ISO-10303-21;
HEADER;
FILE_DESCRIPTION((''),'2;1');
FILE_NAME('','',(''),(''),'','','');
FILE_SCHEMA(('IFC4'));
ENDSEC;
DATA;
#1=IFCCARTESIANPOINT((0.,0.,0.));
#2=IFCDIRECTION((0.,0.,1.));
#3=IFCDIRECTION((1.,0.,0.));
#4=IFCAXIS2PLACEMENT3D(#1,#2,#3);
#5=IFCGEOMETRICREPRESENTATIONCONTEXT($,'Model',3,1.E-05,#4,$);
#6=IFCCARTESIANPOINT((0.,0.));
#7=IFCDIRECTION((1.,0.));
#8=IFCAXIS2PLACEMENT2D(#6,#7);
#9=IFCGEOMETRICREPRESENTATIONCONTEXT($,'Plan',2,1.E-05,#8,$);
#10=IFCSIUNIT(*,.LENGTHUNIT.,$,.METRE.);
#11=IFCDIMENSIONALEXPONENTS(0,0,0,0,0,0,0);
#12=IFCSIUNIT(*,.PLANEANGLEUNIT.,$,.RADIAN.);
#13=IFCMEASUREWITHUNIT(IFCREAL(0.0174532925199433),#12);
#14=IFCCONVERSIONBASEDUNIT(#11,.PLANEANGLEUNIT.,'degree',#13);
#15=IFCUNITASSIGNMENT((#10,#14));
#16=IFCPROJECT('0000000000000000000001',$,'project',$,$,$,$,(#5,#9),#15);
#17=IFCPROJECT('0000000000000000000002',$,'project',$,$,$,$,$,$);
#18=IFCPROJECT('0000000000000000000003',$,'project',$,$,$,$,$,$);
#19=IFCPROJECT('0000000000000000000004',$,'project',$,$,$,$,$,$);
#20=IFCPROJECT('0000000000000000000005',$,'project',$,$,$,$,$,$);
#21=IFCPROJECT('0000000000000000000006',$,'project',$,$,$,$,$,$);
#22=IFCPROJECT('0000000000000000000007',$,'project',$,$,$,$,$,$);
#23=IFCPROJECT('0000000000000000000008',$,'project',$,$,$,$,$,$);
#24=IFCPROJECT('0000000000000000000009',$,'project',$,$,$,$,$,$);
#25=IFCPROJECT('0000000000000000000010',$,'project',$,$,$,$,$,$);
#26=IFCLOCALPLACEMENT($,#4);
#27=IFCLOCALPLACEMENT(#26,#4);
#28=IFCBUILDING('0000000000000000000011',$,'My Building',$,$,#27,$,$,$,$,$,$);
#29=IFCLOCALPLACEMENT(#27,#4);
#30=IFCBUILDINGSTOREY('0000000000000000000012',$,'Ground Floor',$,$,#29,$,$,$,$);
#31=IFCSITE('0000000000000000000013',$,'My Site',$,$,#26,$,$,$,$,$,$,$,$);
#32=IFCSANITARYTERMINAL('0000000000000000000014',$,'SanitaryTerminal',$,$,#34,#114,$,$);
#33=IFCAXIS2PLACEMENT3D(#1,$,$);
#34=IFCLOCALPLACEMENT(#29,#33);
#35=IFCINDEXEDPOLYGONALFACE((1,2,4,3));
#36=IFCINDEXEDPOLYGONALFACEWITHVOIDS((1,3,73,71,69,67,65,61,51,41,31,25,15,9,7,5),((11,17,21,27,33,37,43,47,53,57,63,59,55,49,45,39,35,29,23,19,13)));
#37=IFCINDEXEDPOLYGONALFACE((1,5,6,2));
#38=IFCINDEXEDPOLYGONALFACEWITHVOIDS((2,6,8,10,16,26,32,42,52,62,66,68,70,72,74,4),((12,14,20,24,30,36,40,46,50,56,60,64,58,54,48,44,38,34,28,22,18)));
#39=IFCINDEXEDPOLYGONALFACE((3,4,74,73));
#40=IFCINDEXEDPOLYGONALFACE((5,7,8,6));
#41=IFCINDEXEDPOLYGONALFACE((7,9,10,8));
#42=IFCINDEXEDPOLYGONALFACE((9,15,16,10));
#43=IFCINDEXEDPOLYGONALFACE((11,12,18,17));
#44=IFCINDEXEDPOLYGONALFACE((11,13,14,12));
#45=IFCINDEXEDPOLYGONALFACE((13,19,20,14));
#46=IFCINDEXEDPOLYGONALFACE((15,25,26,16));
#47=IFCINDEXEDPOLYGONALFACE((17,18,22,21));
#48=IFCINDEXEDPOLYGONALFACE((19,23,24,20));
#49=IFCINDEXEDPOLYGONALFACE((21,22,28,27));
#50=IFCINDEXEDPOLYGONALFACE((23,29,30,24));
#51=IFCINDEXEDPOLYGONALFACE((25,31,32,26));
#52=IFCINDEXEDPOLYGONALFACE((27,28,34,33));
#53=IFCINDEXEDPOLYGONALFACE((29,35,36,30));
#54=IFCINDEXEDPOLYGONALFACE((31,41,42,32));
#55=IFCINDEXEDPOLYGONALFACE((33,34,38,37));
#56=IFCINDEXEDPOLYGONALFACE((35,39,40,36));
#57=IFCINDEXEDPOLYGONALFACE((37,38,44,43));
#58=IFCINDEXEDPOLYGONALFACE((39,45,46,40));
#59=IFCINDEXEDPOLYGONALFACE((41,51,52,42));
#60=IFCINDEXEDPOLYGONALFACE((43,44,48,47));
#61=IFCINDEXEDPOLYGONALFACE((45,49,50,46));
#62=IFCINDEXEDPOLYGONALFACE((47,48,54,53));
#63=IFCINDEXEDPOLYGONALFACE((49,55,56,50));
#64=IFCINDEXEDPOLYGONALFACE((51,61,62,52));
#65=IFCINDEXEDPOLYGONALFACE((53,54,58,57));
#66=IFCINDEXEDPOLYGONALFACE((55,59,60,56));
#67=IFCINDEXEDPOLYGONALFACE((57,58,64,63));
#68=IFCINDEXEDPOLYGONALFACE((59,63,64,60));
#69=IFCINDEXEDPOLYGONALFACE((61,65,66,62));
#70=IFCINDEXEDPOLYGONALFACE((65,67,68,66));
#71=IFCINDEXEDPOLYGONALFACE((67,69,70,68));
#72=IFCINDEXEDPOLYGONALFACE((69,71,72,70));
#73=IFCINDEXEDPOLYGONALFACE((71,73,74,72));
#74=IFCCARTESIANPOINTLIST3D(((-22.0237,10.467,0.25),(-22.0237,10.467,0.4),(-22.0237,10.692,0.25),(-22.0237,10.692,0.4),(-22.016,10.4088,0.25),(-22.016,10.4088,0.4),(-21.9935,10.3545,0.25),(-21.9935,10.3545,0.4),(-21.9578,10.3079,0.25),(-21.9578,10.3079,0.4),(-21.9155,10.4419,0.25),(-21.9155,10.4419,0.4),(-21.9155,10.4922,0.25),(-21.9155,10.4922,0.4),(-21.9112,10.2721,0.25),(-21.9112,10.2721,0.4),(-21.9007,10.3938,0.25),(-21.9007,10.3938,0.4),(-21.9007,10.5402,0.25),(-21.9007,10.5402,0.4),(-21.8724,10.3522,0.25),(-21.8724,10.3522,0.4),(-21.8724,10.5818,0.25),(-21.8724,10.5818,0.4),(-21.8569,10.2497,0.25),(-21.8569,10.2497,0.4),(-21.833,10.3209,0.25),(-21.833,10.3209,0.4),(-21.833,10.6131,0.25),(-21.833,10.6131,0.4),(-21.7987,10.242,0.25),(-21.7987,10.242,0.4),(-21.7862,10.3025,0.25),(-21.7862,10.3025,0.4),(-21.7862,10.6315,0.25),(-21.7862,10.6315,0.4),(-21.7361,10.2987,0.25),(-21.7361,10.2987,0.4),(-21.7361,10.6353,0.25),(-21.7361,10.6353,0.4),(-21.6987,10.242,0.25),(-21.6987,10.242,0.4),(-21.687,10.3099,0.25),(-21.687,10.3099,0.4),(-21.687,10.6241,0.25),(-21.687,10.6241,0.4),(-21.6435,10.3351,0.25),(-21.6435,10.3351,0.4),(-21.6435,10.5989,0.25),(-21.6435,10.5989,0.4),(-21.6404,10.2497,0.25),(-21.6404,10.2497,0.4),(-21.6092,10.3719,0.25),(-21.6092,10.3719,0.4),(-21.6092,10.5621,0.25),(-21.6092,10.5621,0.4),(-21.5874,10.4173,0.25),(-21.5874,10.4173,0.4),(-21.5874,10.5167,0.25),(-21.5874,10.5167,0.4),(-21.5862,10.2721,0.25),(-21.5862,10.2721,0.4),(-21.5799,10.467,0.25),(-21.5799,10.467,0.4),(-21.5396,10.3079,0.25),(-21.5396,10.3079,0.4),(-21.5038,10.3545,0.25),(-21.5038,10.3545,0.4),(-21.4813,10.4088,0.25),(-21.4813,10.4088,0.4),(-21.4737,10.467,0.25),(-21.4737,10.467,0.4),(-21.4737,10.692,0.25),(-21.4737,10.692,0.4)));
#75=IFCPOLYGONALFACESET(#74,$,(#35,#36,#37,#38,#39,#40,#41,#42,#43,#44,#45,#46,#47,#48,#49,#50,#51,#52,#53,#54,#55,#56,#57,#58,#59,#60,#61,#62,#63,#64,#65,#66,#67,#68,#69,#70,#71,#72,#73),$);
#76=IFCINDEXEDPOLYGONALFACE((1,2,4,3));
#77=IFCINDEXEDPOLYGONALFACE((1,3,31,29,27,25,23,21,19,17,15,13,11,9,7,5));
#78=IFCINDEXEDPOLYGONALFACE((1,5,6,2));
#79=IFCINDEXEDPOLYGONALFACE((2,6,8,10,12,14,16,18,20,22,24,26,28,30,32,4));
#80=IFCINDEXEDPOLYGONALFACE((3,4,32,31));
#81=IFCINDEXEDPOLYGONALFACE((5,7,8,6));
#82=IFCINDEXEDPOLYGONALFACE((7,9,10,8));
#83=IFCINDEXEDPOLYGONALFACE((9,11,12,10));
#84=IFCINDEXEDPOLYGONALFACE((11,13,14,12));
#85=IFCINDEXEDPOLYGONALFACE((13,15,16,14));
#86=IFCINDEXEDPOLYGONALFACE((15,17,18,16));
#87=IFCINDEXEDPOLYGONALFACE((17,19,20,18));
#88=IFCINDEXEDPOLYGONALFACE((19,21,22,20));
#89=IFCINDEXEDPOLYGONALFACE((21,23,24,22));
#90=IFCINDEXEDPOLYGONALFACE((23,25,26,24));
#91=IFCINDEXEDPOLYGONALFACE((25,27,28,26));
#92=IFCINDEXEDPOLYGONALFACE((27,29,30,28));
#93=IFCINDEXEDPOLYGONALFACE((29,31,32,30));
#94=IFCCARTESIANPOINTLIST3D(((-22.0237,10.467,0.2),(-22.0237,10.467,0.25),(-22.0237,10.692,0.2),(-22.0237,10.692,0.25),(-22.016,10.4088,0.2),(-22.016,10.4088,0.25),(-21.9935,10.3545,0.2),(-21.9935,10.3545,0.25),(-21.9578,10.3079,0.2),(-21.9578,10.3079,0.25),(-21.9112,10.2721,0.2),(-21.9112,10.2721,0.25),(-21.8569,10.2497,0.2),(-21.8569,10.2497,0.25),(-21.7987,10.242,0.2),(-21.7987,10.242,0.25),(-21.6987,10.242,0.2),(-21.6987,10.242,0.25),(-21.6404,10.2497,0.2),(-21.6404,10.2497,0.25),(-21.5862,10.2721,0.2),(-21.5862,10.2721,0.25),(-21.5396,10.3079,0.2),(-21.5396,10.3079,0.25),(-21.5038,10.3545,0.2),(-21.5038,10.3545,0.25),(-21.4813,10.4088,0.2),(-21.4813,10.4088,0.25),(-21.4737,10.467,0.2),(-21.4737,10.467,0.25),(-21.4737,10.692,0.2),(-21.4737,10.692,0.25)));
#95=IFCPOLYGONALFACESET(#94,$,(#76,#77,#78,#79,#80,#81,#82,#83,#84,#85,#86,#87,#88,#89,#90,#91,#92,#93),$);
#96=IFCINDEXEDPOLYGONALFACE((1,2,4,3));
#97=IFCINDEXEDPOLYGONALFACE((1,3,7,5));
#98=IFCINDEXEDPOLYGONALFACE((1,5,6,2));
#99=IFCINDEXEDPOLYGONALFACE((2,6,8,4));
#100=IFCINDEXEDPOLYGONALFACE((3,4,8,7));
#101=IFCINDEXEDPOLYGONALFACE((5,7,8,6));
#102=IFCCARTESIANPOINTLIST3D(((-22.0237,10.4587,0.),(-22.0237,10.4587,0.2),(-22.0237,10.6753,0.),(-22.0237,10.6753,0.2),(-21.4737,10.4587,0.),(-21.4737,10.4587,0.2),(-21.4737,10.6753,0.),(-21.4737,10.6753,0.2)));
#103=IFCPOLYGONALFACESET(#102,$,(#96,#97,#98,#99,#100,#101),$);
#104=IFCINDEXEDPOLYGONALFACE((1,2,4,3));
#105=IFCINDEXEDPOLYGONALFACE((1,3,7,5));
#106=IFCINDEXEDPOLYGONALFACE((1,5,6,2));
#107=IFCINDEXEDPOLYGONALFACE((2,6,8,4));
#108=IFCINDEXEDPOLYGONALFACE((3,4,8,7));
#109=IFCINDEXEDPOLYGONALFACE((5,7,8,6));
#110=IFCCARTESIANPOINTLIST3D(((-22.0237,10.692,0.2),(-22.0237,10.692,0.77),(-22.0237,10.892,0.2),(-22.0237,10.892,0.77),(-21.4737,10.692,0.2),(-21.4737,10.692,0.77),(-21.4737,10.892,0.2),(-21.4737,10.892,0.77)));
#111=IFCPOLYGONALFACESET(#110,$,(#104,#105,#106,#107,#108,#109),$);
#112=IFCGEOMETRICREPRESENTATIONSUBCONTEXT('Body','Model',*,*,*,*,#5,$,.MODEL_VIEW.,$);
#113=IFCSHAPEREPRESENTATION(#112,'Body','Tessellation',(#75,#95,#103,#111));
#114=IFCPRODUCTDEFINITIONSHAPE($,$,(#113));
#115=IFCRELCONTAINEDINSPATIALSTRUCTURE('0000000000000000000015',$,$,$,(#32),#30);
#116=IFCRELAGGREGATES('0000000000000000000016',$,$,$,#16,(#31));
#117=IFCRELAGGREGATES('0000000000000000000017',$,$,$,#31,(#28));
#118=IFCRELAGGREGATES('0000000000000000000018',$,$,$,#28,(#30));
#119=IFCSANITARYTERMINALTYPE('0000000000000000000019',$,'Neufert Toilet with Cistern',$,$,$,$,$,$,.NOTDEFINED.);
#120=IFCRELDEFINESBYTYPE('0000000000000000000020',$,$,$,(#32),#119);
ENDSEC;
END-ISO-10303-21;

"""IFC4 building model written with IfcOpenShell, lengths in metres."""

from ifc_helpers import new_model, entity, si_unit, converted_unit, frame, frame_2d, origin_with_axes, origin_2d_with_axis, place, context, subcontext, project, spatial, line, arc, indexed_curve, circle_curve, outline, extrude, shape, source, transform, mapped, type_object, type_shapes, element, save


model = new_model("IFC4")

# Units and contexts
model_context = context("Model", 3, precision=1e-05, world=origin_with_axes())
plan_context = context("Plan", 2, precision=1e-05, world=origin_2d_with_axis())
body_context_1 = subcontext(model_context, "Body", "Model", "MODEL_VIEW")
body_context_2 = subcontext(plan_context, "Body", "Plan", "PLAN_VIEW")
ifc_project_1 = project(units=[si_unit("LENGTHUNIT", "METRE"), converted_unit("PLANEANGLEUNIT", "degree", entity("IfcReal", 0.0174532925199433), si_unit("PLANEANGLEUNIT", "RADIAN"), dimensions=[0, 0, 0, 0, 0, 0, 0])], contexts=[model_context, plan_context])
ifc_project_2 = project()
ifc_project_3 = project()
ifc_project_4 = project()
ifc_project_5 = project()
ifc_project_6 = project()
ifc_project_7 = project()
ifc_project_8 = project()
ifc_project_9 = project()
ifc_project_10 = project()

# Site, building, storey
site_placement = place(None, origin_with_axes())
site = spatial("IfcSite", under=ifc_project_1, at=site_placement, Name="My Site")
building_placement = place(site_placement, origin_with_axes())
building = spatial("IfcBuilding", under=site, at=building_placement, Name="My Building")
storey_placement = place(building_placement, origin_with_axes())
storey = spatial("IfcBuildingStorey", under=building, at=storey_placement, Name="Ground Floor")

# Sanitary terminal
sanitary_terminal_type_1 = type_object("IfcSanitaryTerminalType", Name="Neufert Toilet with Cistern", PredefinedType="NOTDEFINED")
shared_shape_1 = source(origin_with_axes(), body_context_1, "Body", "SweptSolid", [
    extrude(outline(indexed_curve([(-0.275, -0.2), (0.275, -0.2), (0.275, -0.425), (0.2091, -0.5841), (0.05, -0.65), (-0.05, -0.65), (-0.2091, -0.5841), (-0.275, -0.425)], segments=[line(1, 2), line(2, 3), arc(3, 4, 5), line(5, 6), arc(6, 7, 8), line(8, 1)]), holes=[circle_curve(frame_2d((0.0, -0.425)), 0.1688)]), frame((0.0, 0.0, 0.25), z_axis=(0.0, 0.0, 1.0), x_axis=(1.0, 0.0, 0.0)), (0.0, 0.0, 1.0), 0.15),
    extrude(outline(indexed_curve([(-0.275, -0.2), (0.275, -0.2), (0.275, -0.425), (0.2091, -0.5841), (0.05, -0.65), (-0.05, -0.65), (-0.2091, -0.5841), (-0.275, -0.425)], segments=[line(1, 2), line(2, 3), arc(3, 4, 5), line(5, 6), arc(6, 7, 8), line(8, 1)])), frame((0.0, 0.0, 0.2), z_axis=(0.0, 0.0, 1.0), x_axis=(1.0, 0.0, 0.0)), (0.0, 0.0, 1.0), 0.05),
    extrude(outline(indexed_curve([(-0.275, -0.2167), (0.275, -0.2167), (0.275, -0.4333), (-0.275, -0.4333)], segments=[line(1, 2), line(2, 3), line(3, 4), line(4, 1)])), origin_with_axes(), (0.0, 0.0, 1.0), 0.2),
    extrude(outline(indexed_curve([(-0.275, 0.0), (0.275, 0.0), (0.275, -0.2), (-0.275, -0.2)], segments=[line(1, 2), line(2, 3), line(3, 4), line(4, 1)])), frame((0.0, 0.0, 0.2), z_axis=(0.0, 0.0, 1.0), x_axis=(1.0, 0.0, 0.0)), (0.0, 0.0, 1.0), 0.57),
])
shared_shape_2 = source(origin_with_axes(), body_context_2, "Body", "Curve2D", [
    entity("IfcIndexedPolyCurve", entity("IfcCartesianPointList2D", [[-0.275, 0.0], [0.275, 0.0], [0.275, -0.2], [-0.275, -0.2]]), [entity("IfcLineIndex", [1, 2]), entity("IfcLineIndex", [2, 3]), entity("IfcLineIndex", [3, 4]), entity("IfcLineIndex", [4, 1])]),
    entity("IfcIndexedPolyCurve", entity("IfcCartesianPointList2D", [[0.165, -0.2], [0.1925, -0.335]]), [entity("IfcLineIndex", [1, 2])]),
    entity("IfcTrimmedCurve", entity("IfcEllipse", entity("IfcAxis2Placement2D", entity("IfcCartesianPoint", [0.0, -0.335]), entity("IfcDirection", [1.0, 0.0])), 0.1925, 0.315), [entity("IfcCartesianPoint", [-0.1925, -0.335])], [entity("IfcCartesianPoint", [0.1925, -0.335])], True, "CARTESIAN"),
    entity("IfcIndexedPolyCurve", entity("IfcCartesianPointList2D", [[-0.165, -0.2], [-0.1925, -0.335]]), [entity("IfcLineIndex", [1, 2])]),
    entity("IfcEllipse", entity("IfcAxis2Placement2D", entity("IfcCartesianPoint", [0.0, -0.452]), entity("IfcDirection", [1.0, 0.0])), 0.1313, 0.1575),
    entity("IfcIndexedPolyCurve", entity("IfcCartesianPointList2D", [[-0.0344, -0.452], [-0.0344, -0.4295], [0.0344, -0.4295], [0.0344, -0.452]]), [entity("IfcLineIndex", [1, 2]), entity("IfcLineIndex", [2, 3]), entity("IfcLineIndex", [3, 4])]),
    entity("IfcTrimmedCurve", entity("IfcEllipse", entity("IfcAxis2Placement2D", entity("IfcCartesianPoint", [0.0, -0.452]), entity("IfcDirection", [1.0, 0.0])), 0.0344, 0.0225), [entity("IfcCartesianPoint", [-0.0344, -0.452])], [entity("IfcCartesianPoint", [0.0344, -0.452])], True, "CARTESIAN"),
])
type_shapes(sanitary_terminal_type_1, [shared_shape_1, shared_shape_2])
sanitary_terminal_1_placement = place(storey_placement, frame((-21.7487, 10.892, 0.0), z_axis=(0.0, 0.0, 1.0), x_axis=(1.0, 0.0, 0.0)))
element("IfcSanitaryTerminal", 1, at=sanitary_terminal_1_placement, inside=storey, type_object=sanitary_terminal_type_1, Name="SanitaryTerminal", shapes=[
    shape(body_context_1, "Body", "MappedRepresentation", [mapped(shared_shape_1, transform((0.0, 0.0, 0.0), x_axis=(1.0, 0.0, 0.0), y_axis=(0.0, 1.0, 0.0), z_axis=(0.0, 0.0, 1.0), scale=1.0))]),
    shape(body_context_2, "Body", "MappedRepresentation", [mapped(shared_shape_2, transform((0.0, 0.0, 0.0), x_axis=(1.0, 0.0, 0.0), y_axis=(0.0, 1.0, 0.0), z_axis=(0.0, 0.0, 1.0), scale=1.0))]),
])

save(model, "model.ifc")
